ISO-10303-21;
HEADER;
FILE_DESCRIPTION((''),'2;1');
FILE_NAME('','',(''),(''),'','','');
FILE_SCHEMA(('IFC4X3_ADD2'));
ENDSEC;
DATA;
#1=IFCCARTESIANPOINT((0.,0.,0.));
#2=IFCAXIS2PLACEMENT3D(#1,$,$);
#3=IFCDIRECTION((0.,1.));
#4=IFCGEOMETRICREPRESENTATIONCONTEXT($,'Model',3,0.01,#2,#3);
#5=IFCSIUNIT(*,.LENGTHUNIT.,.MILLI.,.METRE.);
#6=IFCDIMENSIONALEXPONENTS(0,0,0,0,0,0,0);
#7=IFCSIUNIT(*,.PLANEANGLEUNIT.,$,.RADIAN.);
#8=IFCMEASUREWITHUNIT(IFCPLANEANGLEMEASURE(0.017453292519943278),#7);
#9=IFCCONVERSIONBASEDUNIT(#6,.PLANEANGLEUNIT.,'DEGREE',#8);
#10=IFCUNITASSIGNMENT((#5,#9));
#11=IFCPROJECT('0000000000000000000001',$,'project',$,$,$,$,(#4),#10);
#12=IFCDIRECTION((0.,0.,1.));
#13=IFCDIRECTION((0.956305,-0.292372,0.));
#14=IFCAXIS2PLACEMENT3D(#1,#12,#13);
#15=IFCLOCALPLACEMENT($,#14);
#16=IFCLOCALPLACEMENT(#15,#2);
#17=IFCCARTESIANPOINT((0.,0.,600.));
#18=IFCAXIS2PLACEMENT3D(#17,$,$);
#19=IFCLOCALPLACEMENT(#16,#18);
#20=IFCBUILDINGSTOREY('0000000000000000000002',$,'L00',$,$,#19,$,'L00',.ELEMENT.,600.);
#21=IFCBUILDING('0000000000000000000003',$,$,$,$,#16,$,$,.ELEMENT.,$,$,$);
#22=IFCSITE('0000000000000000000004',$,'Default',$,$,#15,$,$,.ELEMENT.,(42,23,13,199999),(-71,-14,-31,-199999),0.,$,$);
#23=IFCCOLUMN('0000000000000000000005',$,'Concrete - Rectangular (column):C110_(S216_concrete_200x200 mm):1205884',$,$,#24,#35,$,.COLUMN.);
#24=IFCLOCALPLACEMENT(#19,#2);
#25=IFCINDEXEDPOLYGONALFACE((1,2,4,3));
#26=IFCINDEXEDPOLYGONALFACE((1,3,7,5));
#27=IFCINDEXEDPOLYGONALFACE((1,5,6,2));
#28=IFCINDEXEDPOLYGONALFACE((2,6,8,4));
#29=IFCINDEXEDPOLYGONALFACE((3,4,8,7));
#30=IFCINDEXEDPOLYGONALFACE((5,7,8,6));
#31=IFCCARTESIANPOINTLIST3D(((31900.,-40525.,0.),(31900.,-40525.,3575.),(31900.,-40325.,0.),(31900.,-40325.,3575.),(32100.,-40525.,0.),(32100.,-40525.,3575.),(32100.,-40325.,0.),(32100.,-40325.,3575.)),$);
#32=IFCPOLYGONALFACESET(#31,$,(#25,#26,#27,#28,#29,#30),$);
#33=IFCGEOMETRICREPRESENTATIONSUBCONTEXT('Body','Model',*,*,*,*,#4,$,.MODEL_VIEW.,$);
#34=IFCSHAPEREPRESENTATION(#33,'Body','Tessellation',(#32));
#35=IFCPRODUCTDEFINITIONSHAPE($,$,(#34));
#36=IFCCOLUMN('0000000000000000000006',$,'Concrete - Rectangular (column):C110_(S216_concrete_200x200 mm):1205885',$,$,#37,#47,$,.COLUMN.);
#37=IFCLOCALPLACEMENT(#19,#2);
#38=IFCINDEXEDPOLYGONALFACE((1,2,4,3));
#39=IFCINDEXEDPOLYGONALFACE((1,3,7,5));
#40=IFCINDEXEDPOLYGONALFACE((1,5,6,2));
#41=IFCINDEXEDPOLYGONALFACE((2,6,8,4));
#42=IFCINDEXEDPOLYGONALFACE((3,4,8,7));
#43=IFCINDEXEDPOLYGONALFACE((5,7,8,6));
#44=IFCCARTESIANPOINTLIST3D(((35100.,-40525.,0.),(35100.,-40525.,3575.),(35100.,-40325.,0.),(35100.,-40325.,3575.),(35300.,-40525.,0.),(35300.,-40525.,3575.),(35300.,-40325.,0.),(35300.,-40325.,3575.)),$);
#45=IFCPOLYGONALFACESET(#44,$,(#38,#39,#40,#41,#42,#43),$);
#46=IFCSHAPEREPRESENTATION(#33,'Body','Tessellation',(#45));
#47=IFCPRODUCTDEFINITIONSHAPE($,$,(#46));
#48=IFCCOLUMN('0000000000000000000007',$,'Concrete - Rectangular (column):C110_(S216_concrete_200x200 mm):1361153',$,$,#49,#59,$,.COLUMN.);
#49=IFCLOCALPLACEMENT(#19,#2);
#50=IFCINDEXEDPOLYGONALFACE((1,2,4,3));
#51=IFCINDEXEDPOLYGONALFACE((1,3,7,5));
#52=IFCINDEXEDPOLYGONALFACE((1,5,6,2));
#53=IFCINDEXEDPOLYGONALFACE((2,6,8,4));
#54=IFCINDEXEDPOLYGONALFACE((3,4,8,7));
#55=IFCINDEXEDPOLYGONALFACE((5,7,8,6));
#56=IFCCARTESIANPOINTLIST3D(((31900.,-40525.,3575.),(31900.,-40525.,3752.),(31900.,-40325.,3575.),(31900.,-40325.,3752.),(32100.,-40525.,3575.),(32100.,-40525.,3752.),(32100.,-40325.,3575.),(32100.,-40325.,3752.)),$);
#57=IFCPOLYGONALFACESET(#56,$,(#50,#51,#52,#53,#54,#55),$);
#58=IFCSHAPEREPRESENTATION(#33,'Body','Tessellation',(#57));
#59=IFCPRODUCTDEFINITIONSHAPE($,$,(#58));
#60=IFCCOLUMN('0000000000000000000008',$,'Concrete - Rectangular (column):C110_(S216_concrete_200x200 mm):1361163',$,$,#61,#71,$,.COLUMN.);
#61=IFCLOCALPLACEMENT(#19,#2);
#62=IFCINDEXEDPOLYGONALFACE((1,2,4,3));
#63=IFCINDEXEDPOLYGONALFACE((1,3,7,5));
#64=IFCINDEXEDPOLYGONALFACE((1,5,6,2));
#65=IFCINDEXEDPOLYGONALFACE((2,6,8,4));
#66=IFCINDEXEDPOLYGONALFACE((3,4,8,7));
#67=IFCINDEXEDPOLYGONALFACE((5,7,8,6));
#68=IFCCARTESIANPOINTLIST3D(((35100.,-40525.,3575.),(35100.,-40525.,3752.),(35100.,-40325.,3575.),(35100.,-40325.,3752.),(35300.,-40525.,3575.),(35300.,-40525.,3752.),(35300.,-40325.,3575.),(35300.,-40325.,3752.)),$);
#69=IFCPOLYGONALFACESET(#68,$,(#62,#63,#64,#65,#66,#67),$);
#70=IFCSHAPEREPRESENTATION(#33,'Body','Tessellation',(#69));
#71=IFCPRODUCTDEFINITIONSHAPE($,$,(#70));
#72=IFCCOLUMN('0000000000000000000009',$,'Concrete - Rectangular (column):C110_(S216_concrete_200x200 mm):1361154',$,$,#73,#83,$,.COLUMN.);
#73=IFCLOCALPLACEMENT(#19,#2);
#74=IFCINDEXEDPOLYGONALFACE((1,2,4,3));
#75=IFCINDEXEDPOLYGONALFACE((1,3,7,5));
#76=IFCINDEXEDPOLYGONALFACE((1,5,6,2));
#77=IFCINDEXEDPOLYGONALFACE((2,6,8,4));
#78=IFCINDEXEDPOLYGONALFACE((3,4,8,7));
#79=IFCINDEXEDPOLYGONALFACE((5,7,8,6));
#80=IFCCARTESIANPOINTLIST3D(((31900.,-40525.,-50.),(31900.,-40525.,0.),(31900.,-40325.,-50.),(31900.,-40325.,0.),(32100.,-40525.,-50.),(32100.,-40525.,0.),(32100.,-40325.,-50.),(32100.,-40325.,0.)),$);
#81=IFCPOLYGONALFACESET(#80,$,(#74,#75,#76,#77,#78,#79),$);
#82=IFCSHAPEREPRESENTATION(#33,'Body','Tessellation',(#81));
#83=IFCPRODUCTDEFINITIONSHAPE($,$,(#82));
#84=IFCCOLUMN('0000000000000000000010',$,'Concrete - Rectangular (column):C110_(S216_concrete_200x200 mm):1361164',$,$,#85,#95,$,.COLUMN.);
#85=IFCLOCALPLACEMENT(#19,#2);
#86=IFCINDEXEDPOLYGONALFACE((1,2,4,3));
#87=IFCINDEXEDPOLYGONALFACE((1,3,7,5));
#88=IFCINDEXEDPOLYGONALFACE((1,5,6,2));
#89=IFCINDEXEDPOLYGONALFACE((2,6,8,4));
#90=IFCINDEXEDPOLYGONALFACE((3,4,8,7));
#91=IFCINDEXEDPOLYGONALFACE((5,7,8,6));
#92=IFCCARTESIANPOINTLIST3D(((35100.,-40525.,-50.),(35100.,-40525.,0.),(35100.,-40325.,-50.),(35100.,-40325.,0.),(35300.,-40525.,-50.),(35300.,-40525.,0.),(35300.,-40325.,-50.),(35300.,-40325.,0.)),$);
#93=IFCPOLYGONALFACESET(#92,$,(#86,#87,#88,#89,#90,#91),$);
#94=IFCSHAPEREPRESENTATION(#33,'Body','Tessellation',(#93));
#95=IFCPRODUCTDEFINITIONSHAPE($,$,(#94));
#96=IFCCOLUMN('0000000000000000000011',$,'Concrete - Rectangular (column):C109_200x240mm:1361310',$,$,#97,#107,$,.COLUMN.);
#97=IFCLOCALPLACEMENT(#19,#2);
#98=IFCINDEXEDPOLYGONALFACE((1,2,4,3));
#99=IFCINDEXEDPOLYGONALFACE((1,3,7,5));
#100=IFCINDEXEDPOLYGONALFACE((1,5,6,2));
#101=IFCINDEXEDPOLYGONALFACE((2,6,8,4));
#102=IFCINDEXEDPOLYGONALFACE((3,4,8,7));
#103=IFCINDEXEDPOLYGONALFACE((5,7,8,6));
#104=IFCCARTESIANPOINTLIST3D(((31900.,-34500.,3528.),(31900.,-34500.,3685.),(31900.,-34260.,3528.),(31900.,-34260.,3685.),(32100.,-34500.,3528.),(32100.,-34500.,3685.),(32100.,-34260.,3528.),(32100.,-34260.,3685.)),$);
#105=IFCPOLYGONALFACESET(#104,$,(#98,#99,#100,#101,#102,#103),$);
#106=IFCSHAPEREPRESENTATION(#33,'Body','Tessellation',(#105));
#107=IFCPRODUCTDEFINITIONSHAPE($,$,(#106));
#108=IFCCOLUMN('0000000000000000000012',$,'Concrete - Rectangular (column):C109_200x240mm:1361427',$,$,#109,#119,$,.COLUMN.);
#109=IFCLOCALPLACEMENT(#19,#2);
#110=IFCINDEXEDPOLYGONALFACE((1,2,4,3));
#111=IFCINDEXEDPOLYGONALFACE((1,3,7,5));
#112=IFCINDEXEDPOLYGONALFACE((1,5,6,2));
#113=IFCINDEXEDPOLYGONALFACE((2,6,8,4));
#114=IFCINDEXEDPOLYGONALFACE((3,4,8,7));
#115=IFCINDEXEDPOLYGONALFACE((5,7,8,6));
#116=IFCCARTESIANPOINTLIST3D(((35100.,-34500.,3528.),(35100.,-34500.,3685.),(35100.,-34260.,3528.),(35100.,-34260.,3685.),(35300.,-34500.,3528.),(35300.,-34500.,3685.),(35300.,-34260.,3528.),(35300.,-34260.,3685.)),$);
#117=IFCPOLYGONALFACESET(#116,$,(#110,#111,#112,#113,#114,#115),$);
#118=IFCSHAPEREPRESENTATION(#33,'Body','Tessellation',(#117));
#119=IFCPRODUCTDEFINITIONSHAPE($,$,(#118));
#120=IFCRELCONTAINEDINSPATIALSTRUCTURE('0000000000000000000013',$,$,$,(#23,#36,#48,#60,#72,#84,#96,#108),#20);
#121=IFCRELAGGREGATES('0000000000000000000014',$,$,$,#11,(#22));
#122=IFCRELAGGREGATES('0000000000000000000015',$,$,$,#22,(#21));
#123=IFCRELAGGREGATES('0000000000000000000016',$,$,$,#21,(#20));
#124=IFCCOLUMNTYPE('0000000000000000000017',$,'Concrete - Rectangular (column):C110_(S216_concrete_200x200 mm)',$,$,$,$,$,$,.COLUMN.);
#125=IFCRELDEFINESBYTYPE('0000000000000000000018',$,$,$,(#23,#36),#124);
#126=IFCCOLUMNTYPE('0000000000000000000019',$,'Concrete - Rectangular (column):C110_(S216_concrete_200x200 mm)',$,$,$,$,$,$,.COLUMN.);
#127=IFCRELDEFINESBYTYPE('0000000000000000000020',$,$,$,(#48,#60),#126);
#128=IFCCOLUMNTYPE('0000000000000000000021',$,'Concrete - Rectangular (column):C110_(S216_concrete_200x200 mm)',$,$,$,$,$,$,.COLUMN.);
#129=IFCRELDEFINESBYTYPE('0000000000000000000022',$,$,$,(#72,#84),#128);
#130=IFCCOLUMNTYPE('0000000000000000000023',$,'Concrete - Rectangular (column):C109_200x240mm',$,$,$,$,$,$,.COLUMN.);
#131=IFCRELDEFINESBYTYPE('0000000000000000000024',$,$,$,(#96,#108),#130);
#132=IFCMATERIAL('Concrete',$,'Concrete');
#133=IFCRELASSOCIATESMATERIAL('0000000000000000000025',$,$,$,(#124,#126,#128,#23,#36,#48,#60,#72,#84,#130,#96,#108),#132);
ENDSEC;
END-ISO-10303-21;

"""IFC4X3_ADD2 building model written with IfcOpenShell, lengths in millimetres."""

from ifc_helpers import new_model, entity, si_unit, converted_unit, direction, frame, frame_2d, origin, origin_2d_with_axis, place, context, subcontext, project, spatial, rectangle, extrude, source, transform, mapped, material, material_profile, profile_set, profile_usage, type_object, type_shapes, element, save


model = new_model("IFC4X3_ADD2")

# Units and contexts
model_context = context("Model", 3, precision=0.01, world=origin(), true_north=direction((0.0, 1.0)))
body_context = subcontext(model_context, "Body", "Model", "MODEL_VIEW")
ifc_project = project(units=[si_unit("LENGTHUNIT", "METRE", prefix="MILLI"), converted_unit("PLANEANGLEUNIT", "DEGREE", entity("IfcPlaneAngleMeasure", 0.017453292519943278), si_unit("PLANEANGLEUNIT", "RADIAN"), dimensions=[0, 0, 0, 0, 0, 0, 0])], contexts=[model_context])

# Site, building, storey
site_placement = place(None, frame((0.0, 0.0, 0.0), z_axis=(0.0, 0.0, 1.0), x_axis=(0.956305, -0.292372, 0.0)))
site = spatial("IfcSite", under=ifc_project, at=site_placement, Name="Default", CompositionType="ELEMENT", RefLatitude=(42, 23, 13, 199999), RefLongitude=(-71, -14, -31, -199999), RefElevation=0.0)
building_placement = place(site_placement, origin())
building = spatial("IfcBuilding", under=site, at=building_placement, CompositionType="ELEMENT")
storey_placement = place(building_placement, frame((0.0, 0.0, 600.0)))
storey = spatial("IfcBuildingStorey", under=building, at=storey_placement, Name="L00", LongName="L00", CompositionType="ELEMENT", Elevation=600.0)

# Columns
ifc_material_1 = material(Name="Concrete", Category="Concrete")
ifc_material_profile_1 = material_profile(ifc_material_1, rectangle(XDim=200.0, YDim=200.0, at=origin_2d_with_axis()), Name="C110_(S216_concrete_200x200 mm)")
ifc_profile_set_1 = profile_set([ifc_material_profile_1], Name="C110_(S216_concrete_200x200 mm)")
ifc_profile_usage_1 = profile_usage(ifc_profile_set_1)
column_type_1 = type_object("IfcColumnType", Name="Concrete - Rectangular (column):C110_(S216_concrete_200x200 mm)", PredefinedType="COLUMN", material=ifc_profile_set_1)
shared_shape_1 = source(origin(), body_context, "Body", "SweptSolid", [
    extrude(rectangle(XDim=200.0, YDim=200.0, at=origin_2d_with_axis()), frame((0.0, 0.0, 600.0), z_axis=(0.0, 0.0, 1.0), x_axis=(-1.0, 0.0, 0.0)), (0.0, 0.0, 1.0), 3575.0),
])
type_shapes(column_type_1, [shared_shape_1])
for number, where, name in (
    (1, (32000.0, -40425.0, -600.0), "Concrete - Rectangular (column):C110_(S216_concrete_200x200 mm):1205884"),
    (2, (35200.0, -40425.0, -600.0), "Concrete - Rectangular (column):C110_(S216_concrete_200x200 mm):1205885"),
):
    element("IfcColumn", number, at=place(storey_placement, frame(where)), inside=storey, type_object=column_type_1, material=ifc_profile_usage_1, Name=name, PredefinedType="COLUMN", context=body_context, shape_type="MappedRepresentation", body=[
        mapped(shared_shape_1, transform((0.0, 0.0, 0.0), scale=1.0)),
    ])
column_type_2 = type_object("IfcColumnType", Name="Concrete - Rectangular (column):C110_(S216_concrete_200x200 mm)", PredefinedType="COLUMN", material=ifc_profile_set_1)
shared_shape_2 = source(origin(), body_context, "Body", "SweptSolid", [
    extrude(rectangle(XDim=200.0, YDim=200.0, at=origin_2d_with_axis()), frame((0.0, 0.0, 4175.0), z_axis=(0.0, 0.0, 1.0), x_axis=(-1.0, 0.0, 0.0)), (0.0, 0.0, 1.0), 177.0),
])
type_shapes(column_type_2, [shared_shape_2])
for number, where, name in (
    (3, (32000.0, -40425.0, -600.0), "Concrete - Rectangular (column):C110_(S216_concrete_200x200 mm):1361153"),
    (4, (35200.0, -40425.0, -600.0), "Concrete - Rectangular (column):C110_(S216_concrete_200x200 mm):1361163"),
):
    element("IfcColumn", number, at=place(storey_placement, frame(where)), inside=storey, type_object=column_type_2, material=ifc_profile_usage_1, Name=name, PredefinedType="COLUMN", context=body_context, shape_type="MappedRepresentation", body=[
        mapped(shared_shape_2, transform((0.0, 0.0, 0.0), scale=1.0)),
    ])
column_type_3 = type_object("IfcColumnType", Name="Concrete - Rectangular (column):C110_(S216_concrete_200x200 mm)", PredefinedType="COLUMN", material=ifc_profile_set_1)
shared_shape_3 = source(origin(), body_context, "Body", "SweptSolid", [
    extrude(rectangle(XDim=200.0, YDim=200.0, at=origin_2d_with_axis()), frame((0.0, 0.0, 550.0), z_axis=(0.0, 0.0, 1.0), x_axis=(-1.0, 0.0, 0.0)), (0.0, 0.0, 1.0), 50.0),
])
type_shapes(column_type_3, [shared_shape_3])
for number, where, name in (
    (5, (32000.0, -40425.0, -600.0), "Concrete - Rectangular (column):C110_(S216_concrete_200x200 mm):1361154"),
    (6, (35200.0, -40425.0, -600.0), "Concrete - Rectangular (column):C110_(S216_concrete_200x200 mm):1361164"),
):
    element("IfcColumn", number, at=place(storey_placement, frame(where)), inside=storey, type_object=column_type_3, material=ifc_profile_usage_1, Name=name, PredefinedType="COLUMN", context=body_context, shape_type="MappedRepresentation", body=[
        mapped(shared_shape_3, transform((0.0, 0.0, 0.0), scale=1.0)),
    ])
ifc_material_profile_2 = material_profile(ifc_material_1, rectangle(XDim=200.0, YDim=240.0, at=frame_2d((0.0, 0.0), x_axis=(1.0, 0.0))), Name="C109_200x240mm")
ifc_profile_set_2 = profile_set([ifc_material_profile_2], Name="C109_200x240mm")
ifc_profile_usage_2 = profile_usage(ifc_profile_set_2)
column_type_4 = type_object("IfcColumnType", Name="Concrete - Rectangular (column):C109_200x240mm", PredefinedType="COLUMN", material=ifc_profile_set_2)
shared_shape_4 = source(origin(), body_context, "Body", "SweptSolid", [
    extrude(rectangle(XDim=200.0, YDim=240.0, at=origin_2d_with_axis()), frame((0.0, 0.0, 4128.0), z_axis=(0.0, 0.0, 1.0), x_axis=(-1.0, 0.0, 0.0)), (0.0, 0.0, 1.0), 157.0),
])
type_shapes(column_type_4, [shared_shape_4])
for number, where, name in (
    (7, (32000.0, -34380.0, -600.0), "Concrete - Rectangular (column):C109_200x240mm:1361310"),
    (8, (35200.0, -34380.0, -600.0), "Concrete - Rectangular (column):C109_200x240mm:1361427"),
):
    element("IfcColumn", number, at=place(storey_placement, frame(where)), inside=storey, type_object=column_type_4, material=ifc_profile_usage_2, Name=name, PredefinedType="COLUMN", context=body_context, shape_type="MappedRepresentation", body=[
        mapped(shared_shape_4, transform((0.0, 0.0, 0.0), scale=1.0)),
    ])

save(model, "model.ifc")
